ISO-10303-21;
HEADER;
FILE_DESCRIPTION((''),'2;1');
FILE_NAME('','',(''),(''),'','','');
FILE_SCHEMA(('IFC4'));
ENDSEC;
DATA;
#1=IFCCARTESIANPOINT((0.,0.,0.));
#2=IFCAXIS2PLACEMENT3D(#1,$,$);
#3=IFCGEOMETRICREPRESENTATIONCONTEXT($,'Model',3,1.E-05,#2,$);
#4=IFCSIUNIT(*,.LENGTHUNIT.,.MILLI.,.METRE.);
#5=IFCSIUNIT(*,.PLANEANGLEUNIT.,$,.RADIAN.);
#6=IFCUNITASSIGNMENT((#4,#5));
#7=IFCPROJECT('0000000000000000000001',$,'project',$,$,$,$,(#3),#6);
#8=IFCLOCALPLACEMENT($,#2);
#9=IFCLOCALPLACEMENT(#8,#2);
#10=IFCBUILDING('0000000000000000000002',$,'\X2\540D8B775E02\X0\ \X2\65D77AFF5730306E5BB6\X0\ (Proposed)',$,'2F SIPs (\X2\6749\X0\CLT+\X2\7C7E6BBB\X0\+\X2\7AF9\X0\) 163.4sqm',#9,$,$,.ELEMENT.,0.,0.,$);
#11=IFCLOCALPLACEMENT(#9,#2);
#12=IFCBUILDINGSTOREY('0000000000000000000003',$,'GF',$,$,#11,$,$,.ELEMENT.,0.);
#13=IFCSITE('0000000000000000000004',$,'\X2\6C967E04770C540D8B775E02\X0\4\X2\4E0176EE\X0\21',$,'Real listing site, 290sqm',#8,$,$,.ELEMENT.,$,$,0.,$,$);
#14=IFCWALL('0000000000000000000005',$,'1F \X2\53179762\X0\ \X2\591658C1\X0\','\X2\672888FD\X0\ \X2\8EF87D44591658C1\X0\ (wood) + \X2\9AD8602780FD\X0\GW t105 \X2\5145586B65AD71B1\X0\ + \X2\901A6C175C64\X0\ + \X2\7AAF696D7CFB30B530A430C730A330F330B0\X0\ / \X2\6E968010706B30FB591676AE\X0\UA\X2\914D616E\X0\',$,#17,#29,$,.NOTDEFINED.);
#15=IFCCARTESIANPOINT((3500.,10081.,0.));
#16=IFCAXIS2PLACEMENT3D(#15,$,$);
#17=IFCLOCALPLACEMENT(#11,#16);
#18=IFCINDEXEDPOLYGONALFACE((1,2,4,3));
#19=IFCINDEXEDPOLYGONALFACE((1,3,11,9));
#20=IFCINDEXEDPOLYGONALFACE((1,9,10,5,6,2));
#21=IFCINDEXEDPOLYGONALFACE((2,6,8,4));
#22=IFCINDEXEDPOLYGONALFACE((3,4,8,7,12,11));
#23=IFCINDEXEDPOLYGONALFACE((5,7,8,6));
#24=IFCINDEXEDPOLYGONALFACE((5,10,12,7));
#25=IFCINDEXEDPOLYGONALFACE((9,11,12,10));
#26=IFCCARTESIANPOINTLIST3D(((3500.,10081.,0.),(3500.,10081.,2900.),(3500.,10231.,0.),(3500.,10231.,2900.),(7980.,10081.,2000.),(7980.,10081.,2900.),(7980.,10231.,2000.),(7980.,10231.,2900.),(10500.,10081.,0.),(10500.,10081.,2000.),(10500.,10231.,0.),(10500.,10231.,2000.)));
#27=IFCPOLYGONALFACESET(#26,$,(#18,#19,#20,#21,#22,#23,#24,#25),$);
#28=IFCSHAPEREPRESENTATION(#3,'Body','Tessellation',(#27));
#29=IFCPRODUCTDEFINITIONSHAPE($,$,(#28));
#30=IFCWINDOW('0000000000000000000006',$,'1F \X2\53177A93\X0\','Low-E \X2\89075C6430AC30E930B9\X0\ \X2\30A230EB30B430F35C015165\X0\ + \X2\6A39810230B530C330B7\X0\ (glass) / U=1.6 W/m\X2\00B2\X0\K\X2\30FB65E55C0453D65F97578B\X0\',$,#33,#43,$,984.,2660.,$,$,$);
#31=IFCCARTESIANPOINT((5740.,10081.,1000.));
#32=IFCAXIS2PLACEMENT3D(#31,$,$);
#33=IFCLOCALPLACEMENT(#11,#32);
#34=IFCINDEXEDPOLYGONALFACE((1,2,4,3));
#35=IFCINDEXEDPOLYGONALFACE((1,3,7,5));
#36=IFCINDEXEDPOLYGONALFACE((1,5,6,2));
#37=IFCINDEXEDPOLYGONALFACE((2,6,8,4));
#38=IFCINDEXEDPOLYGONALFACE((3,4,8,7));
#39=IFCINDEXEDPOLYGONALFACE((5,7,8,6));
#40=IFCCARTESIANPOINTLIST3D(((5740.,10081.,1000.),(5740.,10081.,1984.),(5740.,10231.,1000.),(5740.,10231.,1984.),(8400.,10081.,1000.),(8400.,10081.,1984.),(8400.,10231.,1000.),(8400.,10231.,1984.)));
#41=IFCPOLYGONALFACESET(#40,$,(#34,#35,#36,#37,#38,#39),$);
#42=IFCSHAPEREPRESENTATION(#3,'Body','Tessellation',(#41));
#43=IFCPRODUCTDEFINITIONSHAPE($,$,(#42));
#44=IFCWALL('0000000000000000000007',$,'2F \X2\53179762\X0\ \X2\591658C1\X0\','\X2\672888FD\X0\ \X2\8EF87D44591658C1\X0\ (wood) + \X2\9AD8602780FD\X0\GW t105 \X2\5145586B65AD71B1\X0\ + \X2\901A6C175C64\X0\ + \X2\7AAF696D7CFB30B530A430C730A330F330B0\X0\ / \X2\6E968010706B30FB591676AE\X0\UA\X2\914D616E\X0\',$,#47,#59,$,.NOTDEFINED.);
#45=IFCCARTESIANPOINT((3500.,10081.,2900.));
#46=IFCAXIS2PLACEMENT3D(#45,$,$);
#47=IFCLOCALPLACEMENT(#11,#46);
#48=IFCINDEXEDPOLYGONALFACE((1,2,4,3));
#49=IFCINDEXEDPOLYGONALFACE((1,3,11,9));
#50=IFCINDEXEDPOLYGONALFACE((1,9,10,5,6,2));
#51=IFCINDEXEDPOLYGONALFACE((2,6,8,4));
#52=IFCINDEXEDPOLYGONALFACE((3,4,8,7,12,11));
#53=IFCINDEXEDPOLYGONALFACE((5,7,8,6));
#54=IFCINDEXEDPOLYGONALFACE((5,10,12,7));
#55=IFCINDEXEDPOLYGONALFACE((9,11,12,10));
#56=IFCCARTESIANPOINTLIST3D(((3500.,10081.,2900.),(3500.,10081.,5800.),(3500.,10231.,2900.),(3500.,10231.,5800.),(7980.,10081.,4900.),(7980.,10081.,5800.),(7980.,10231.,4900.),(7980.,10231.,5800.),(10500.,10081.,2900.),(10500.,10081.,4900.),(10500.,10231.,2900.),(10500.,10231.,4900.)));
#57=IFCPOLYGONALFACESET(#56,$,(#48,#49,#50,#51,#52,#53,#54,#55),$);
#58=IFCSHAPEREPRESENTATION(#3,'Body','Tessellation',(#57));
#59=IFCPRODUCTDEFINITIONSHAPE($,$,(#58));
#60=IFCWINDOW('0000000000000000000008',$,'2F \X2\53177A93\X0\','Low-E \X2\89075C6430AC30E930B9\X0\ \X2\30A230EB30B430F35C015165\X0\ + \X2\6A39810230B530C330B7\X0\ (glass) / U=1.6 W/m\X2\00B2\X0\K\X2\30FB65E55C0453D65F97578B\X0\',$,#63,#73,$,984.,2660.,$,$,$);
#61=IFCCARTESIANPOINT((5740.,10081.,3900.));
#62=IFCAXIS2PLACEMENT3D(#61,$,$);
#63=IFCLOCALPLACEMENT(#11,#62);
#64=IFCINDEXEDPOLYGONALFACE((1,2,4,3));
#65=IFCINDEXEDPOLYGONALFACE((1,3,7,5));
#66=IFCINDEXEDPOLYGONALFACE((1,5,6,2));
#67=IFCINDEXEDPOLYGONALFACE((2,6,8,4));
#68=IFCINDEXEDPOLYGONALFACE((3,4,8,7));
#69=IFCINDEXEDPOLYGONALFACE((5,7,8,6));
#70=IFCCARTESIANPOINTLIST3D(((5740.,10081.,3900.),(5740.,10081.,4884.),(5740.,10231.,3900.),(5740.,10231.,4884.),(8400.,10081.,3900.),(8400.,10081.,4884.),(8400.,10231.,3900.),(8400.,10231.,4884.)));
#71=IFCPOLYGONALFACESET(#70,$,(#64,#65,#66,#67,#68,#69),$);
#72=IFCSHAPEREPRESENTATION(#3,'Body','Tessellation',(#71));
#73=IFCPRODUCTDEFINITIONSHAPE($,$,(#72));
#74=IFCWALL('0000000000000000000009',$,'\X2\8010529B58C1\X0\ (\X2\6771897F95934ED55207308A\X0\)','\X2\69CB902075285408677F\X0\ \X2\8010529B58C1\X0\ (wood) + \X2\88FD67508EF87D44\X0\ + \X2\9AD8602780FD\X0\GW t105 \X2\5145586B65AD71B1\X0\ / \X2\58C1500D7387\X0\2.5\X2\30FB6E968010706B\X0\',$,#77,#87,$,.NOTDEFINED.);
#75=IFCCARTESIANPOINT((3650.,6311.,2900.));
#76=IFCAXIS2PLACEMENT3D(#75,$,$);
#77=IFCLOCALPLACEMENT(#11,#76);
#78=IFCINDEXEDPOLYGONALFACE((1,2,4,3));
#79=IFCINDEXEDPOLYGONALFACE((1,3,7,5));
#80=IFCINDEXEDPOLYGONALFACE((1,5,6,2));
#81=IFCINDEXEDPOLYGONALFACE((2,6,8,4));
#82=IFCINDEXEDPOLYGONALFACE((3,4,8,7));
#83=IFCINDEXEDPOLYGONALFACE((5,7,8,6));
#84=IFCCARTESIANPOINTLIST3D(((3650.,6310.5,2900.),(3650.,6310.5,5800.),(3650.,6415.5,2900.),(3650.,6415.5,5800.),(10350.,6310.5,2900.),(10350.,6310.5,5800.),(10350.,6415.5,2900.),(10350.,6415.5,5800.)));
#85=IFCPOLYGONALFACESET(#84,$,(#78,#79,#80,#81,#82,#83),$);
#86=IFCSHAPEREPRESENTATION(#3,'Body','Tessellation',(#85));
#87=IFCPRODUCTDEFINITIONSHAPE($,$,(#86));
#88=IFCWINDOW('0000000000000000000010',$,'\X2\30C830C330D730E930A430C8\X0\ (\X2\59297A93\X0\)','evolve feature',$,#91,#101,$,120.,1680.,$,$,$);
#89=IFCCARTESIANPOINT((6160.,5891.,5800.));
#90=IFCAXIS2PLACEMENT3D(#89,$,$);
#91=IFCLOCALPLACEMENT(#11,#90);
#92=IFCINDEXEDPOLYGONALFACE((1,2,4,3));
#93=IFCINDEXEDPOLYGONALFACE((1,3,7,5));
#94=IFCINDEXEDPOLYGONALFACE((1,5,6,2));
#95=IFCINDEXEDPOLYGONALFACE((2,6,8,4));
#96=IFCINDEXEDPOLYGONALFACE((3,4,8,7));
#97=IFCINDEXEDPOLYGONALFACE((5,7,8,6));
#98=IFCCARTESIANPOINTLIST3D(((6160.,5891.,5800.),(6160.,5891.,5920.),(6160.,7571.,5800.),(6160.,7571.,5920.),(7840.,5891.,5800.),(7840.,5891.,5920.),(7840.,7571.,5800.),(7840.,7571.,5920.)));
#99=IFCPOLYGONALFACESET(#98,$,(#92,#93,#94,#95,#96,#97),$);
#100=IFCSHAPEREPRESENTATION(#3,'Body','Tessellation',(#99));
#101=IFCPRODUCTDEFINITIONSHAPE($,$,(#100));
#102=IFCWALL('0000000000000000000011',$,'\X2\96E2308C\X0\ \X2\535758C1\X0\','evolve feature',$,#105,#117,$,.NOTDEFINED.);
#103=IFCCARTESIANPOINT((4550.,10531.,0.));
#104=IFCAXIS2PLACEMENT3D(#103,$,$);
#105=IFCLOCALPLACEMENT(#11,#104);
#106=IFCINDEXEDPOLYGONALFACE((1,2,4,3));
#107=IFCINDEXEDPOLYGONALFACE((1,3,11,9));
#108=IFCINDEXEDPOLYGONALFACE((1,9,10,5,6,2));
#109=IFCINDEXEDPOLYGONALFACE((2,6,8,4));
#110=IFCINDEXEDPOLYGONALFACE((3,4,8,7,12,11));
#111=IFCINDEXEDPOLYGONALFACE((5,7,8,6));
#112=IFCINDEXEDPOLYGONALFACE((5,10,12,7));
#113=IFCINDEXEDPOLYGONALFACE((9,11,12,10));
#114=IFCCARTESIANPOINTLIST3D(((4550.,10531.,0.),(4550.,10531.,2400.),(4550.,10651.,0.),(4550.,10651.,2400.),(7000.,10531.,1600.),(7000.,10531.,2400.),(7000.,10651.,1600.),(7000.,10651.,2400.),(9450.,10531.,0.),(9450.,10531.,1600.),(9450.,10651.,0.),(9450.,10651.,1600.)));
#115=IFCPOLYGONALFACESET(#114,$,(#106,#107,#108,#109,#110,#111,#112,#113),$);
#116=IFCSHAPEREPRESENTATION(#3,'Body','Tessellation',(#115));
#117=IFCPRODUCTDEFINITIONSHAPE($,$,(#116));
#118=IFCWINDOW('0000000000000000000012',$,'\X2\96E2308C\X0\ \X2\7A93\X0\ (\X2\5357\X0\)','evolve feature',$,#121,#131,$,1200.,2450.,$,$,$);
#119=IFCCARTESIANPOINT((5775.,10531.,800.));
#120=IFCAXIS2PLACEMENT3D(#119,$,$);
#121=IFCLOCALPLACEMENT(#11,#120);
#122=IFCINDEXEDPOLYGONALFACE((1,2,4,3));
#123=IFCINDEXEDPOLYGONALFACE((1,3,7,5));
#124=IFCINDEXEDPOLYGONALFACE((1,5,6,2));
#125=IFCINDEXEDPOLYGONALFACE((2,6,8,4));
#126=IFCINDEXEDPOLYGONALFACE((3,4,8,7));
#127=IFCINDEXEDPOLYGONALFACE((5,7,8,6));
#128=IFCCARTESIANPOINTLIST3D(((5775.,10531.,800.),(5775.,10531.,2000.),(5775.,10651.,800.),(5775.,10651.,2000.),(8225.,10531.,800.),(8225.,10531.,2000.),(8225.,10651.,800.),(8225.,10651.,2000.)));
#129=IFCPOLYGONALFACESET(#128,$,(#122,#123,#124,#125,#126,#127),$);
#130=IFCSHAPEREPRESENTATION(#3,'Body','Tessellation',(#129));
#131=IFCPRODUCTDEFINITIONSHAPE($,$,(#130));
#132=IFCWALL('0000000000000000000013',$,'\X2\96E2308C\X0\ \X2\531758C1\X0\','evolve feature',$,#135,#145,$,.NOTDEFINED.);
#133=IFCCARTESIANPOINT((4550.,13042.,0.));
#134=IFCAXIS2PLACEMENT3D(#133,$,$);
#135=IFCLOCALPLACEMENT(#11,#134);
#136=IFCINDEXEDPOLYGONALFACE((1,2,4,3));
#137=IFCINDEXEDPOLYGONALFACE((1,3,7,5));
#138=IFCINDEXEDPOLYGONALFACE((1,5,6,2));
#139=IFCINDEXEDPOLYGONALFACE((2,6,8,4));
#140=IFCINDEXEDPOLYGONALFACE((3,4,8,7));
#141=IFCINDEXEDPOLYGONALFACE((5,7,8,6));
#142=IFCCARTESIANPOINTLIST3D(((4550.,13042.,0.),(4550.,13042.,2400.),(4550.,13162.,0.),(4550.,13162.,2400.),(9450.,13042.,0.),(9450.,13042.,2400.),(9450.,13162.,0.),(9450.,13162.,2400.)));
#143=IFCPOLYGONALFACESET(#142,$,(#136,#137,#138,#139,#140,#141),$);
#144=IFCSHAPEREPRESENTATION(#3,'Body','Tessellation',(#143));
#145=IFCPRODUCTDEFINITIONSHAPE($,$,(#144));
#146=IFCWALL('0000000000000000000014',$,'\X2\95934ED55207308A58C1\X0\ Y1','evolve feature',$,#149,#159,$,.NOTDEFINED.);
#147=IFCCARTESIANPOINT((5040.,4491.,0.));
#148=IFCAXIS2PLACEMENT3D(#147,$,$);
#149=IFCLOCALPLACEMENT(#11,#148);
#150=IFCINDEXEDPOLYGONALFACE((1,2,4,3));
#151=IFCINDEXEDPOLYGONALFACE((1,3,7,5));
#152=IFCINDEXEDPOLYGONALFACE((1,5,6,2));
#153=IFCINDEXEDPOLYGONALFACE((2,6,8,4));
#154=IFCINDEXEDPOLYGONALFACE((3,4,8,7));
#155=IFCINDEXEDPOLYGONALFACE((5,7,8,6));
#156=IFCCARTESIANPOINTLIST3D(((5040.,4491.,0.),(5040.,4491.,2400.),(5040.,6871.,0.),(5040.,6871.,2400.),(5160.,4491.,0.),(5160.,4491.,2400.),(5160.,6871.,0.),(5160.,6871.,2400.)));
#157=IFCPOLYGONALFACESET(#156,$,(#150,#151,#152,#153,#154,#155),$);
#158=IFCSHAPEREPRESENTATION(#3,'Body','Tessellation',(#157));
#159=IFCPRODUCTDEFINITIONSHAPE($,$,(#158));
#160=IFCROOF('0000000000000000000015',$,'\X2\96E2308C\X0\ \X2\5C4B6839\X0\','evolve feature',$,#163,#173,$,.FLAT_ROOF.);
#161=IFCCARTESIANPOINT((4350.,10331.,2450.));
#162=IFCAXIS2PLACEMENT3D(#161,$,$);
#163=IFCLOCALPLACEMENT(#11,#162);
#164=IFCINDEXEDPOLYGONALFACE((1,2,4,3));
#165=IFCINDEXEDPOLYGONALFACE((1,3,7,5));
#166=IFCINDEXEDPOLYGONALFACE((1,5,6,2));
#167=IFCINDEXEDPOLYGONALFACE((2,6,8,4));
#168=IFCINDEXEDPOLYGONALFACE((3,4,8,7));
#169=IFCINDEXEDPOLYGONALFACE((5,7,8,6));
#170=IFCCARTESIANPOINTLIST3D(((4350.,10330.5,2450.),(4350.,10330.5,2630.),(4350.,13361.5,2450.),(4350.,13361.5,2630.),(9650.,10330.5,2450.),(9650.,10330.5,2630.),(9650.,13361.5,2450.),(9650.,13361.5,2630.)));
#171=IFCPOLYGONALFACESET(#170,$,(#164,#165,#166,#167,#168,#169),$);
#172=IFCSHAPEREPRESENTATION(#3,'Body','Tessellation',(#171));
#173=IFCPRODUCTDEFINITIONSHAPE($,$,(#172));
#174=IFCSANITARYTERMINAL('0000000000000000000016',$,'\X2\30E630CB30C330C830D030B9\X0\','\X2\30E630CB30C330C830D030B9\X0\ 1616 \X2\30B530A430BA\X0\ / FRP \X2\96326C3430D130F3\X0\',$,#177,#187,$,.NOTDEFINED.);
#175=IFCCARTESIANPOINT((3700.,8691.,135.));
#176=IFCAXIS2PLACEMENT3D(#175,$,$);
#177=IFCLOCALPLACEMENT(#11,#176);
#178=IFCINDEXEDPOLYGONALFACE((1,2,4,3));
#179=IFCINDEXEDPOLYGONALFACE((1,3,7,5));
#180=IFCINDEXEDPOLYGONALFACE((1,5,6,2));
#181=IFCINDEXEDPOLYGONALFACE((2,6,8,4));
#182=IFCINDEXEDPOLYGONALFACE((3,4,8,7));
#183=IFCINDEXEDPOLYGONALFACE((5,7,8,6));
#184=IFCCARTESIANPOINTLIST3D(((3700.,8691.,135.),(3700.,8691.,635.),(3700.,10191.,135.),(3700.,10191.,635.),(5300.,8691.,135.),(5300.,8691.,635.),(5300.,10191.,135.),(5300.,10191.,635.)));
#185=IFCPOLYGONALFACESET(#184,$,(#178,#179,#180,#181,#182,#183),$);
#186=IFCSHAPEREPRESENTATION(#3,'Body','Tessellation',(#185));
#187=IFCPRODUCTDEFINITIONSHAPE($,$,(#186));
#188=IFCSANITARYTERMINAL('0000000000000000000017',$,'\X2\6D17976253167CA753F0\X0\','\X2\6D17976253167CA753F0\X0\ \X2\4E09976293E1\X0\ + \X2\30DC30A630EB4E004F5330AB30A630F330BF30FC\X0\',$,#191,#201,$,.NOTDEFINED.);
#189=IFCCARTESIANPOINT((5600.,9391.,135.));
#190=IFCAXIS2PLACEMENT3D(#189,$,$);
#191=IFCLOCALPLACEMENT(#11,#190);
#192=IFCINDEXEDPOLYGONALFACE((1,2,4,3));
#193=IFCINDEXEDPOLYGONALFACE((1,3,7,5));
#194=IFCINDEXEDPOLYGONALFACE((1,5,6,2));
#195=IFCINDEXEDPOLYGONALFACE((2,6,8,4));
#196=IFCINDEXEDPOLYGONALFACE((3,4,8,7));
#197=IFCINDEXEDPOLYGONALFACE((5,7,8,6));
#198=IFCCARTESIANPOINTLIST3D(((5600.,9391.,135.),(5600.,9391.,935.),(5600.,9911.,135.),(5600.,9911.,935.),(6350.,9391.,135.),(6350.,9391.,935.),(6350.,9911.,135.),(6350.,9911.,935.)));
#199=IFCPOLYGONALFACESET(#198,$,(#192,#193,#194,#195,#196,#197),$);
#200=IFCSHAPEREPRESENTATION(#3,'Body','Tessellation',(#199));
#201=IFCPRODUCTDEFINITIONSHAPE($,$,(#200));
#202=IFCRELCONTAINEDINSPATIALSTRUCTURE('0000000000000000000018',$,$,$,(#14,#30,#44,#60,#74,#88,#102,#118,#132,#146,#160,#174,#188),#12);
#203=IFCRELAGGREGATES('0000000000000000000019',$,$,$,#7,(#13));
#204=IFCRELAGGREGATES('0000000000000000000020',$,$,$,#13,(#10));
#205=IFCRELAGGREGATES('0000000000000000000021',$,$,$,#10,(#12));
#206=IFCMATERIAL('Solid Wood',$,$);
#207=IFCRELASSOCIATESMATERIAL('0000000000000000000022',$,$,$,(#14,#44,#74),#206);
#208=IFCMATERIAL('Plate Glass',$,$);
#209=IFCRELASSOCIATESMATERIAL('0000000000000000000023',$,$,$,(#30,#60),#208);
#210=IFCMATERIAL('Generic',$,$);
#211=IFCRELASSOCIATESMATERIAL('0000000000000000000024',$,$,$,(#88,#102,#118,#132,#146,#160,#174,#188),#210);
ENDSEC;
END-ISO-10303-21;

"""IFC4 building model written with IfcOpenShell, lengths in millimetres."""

from ifc_helpers import new_model, si_unit, frame, frame_2d, origin, place, context, project, spatial, rectangle, extrude, material, element, fill, save


model = new_model("IFC4")

# Units and contexts
model_context = context("Model", 3, precision=1e-05, world=origin())
ifc_project = project(units=[si_unit("LENGTHUNIT", "METRE", prefix="MILLI"), si_unit("PLANEANGLEUNIT", "RADIAN")], contexts=[model_context])

# Site, building, storey
site_placement = place(None, origin())
site = spatial("IfcSite", under=ifc_project, at=site_placement, Name="沖縄県名護市4丁目21", ObjectType="Real listing site, 290sqm", CompositionType="ELEMENT", RefElevation=0.0)
building_placement = place(site_placement, origin())
building = spatial("IfcBuilding", under=site, at=building_placement, Name="名護市 旗竿地の家 (Proposed)", ObjectType="2F SIPs (杉CLT+籾殻+竹) 163.4sqm", CompositionType="ELEMENT", ElevationOfRefHeight=0.0, ElevationOfTerrain=0.0)
storey_placement = place(building_placement, origin())
storey = spatial("IfcBuildingStorey", under=building, at=storey_placement, Name="GF", CompositionType="ELEMENT", Elevation=0.0)

# Shared definitions
ifc_material_1 = material(Name="Generic")

# Wall, opening, window
ifc_material_2 = material(Name="Solid Wood")
wall_1_placement = place(storey_placement, frame((3500.0, 10081.0, 0.0)))
wall_1 = element("IfcWall", 1, at=wall_1_placement, inside=storey, material=ifc_material_2, Name="1F 北面 外壁", Description="木製 軸組外壁 (wood) + 高性能GW t105 充填断熱 + 通気層 + 窯業系サイディング / 準耐火・外皮UA配慮", PredefinedType="NOTDEFINED", context=model_context, shape_type="SweptSolid", body=[
    extrude(rectangle(XDim=7000.0, YDim=150.0, at=frame_2d((3500.0, 75.0))), frame((3500.0, 10081.0, 0.0)), (0.0, 0.0, 1.0), 2900.0),
])
opening_1_placement = place(storey_placement, frame((5740.0, 10081.0, 1000.0)))
opening_1 = element("IfcOpeningElement", 2, at=opening_1_placement, cuts=wall_1, PredefinedType="NOTDEFINED", context=model_context, shape_type="SweptSolid", body=[
    extrude(rectangle(XDim=2660.0, YDim=150.0, at=frame_2d((1330.0, 75.0))), frame((5740.0, 10081.0, 1000.0)), (0.0, 0.0, 1.0), 984.0),
])
ifc_material_3 = material(Name="Plate Glass")
window_1_placement = place(storey_placement, frame((5740.0, 10081.0, 1000.0)))
window_1 = element("IfcWindow", 3, at=window_1_placement, inside=storey, material=ifc_material_3, Name="1F 北窓", Description="Low-E 複層ガラス アルゴン封入 + 樹脂サッシ (glass) / U=1.6 W/m²K・日射取得型", OverallHeight=984.0, OverallWidth=2660.0, context=model_context, shape_type="SweptSolid", body=[
    extrude(rectangle(XDim=2660.0, YDim=150.0, at=frame_2d((1330.0, 75.0))), frame((5740.0, 10081.0, 1000.0)), (0.0, 0.0, 1.0), 984.0),
])
fill(opening_1, window_1)

# Wall, opening, window
wall_2_placement = place(storey_placement, frame((3500.0, 10081.0, 2900.0)))
wall_2 = element("IfcWall", 4, at=wall_2_placement, inside=storey, material=ifc_material_2, Name="2F 北面 外壁", Description="木製 軸組外壁 (wood) + 高性能GW t105 充填断熱 + 通気層 + 窯業系サイディング / 準耐火・外皮UA配慮", PredefinedType="NOTDEFINED", context=model_context, shape_type="SweptSolid", body=[
    extrude(rectangle(XDim=7000.0, YDim=150.0, at=frame_2d((3500.0, 75.0))), frame((3500.0, 10081.0, 2900.0)), (0.0, 0.0, 1.0), 2900.0),
])
opening_2_placement = place(storey_placement, frame((5740.0, 10081.0, 3900.0)))
opening_2 = element("IfcOpeningElement", 5, at=opening_2_placement, cuts=wall_2, PredefinedType="NOTDEFINED", context=model_context, shape_type="SweptSolid", body=[
    extrude(rectangle(XDim=2660.0, YDim=150.0, at=frame_2d((1330.0, 75.0))), frame((5740.0, 10081.0, 3900.0)), (0.0, 0.0, 1.0), 984.0),
])
window_2_placement = place(storey_placement, frame((5740.0, 10081.0, 3900.0)))
window_2 = element("IfcWindow", 6, at=window_2_placement, inside=storey, material=ifc_material_3, Name="2F 北窓", Description="Low-E 複層ガラス アルゴン封入 + 樹脂サッシ (glass) / U=1.6 W/m²K・日射取得型", OverallHeight=984.0, OverallWidth=2660.0, context=model_context, shape_type="SweptSolid", body=[
    extrude(rectangle(XDim=2660.0, YDim=150.0, at=frame_2d((1330.0, 75.0))), frame((5740.0, 10081.0, 3900.0)), (0.0, 0.0, 1.0), 984.0),
])
fill(opening_2, window_2)

# Wall
wall_3_placement = place(storey_placement, frame((3650.0, 6311.0, 2900.0)))
element("IfcWall", 7, at=wall_3_placement, inside=storey, material=ifc_material_2, Name="耐力壁 (東西間仕切り)", Description="構造用合板 耐力壁 (wood) + 製材軸組 + 高性能GW t105 充填断熱 / 壁倍率2.5・準耐火", PredefinedType="NOTDEFINED", context=model_context, shape_type="SweptSolid", body=[
    extrude(rectangle(XDim=6700.0, YDim=105.0, at=frame_2d((3350.0, 52.0))), frame((3650.0, 6311.0, 2900.0)), (0.0, 0.0, 1.0), 2900.0),
])

# Window
window_3_placement = place(storey_placement, frame((6160.0, 5891.0, 5800.0)))
element("IfcWindow", 8, at=window_3_placement, inside=storey, material=ifc_material_1, Name="トップライト (天窓)", Description="evolve feature", OverallHeight=120.0, OverallWidth=1680.0, context=model_context, shape_type="SweptSolid", body=[
    extrude(rectangle(XDim=1680.0, YDim=1680.0, at=frame_2d((840.0, 840.0))), frame((6160.0, 5891.0, 5800.0)), (0.0, 0.0, 1.0), 120.0),
])

# Wall, opening, window
wall_4_placement = place(storey_placement, frame((4550.0, 10531.0, 0.0)))
wall_4 = element("IfcWall", 9, at=wall_4_placement, inside=storey, material=ifc_material_1, Name="離れ 南壁", Description="evolve feature", PredefinedType="NOTDEFINED", context=model_context, shape_type="SweptSolid", body=[
    extrude(rectangle(XDim=4900.0, YDim=120.0, at=frame_2d((2450.0, 60.0))), frame((4550.0, 10531.0, 0.0)), (0.0, 0.0, 1.0), 2400.0),
])
opening_3_placement = place(storey_placement, frame((5775.0, 10531.0, 800.0)))
opening_3 = element("IfcOpeningElement", 10, at=opening_3_placement, cuts=wall_4, PredefinedType="NOTDEFINED", context=model_context, shape_type="SweptSolid", body=[
    extrude(rectangle(XDim=2450.0, YDim=120.0, at=frame_2d((1225.0, 60.0))), frame((5775.0, 10531.0, 800.0)), (0.0, 0.0, 1.0), 1200.0),
])
window_4_placement = place(storey_placement, frame((5775.0, 10531.0, 800.0)))
window_4 = element("IfcWindow", 11, at=window_4_placement, inside=storey, material=ifc_material_1, Name="離れ 窓 (南)", Description="evolve feature", OverallHeight=1200.0, OverallWidth=2450.0, context=model_context, shape_type="SweptSolid", body=[
    extrude(rectangle(XDim=2450.0, YDim=120.0, at=frame_2d((1225.0, 60.0))), frame((5775.0, 10531.0, 800.0)), (0.0, 0.0, 1.0), 1200.0),
])
fill(opening_3, window_4)

# Walls
wall_5_placement = place(storey_placement, frame((4550.0, 13042.0, 0.0)))
element("IfcWall", 12, at=wall_5_placement, inside=storey, material=ifc_material_1, Name="離れ 北壁", Description="evolve feature", PredefinedType="NOTDEFINED", context=model_context, shape_type="SweptSolid", body=[
    extrude(rectangle(XDim=4900.0, YDim=120.0, at=frame_2d((2450.0, 60.0))), frame((4550.0, 13042.0, 0.0)), (0.0, 0.0, 1.0), 2400.0),
])
wall_6_placement = place(storey_placement, frame((5040.0, 4491.0, 0.0)))
element("IfcWall", 13, at=wall_6_placement, inside=storey, material=ifc_material_1, Name="間仕切り壁 Y1", Description="evolve feature", PredefinedType="NOTDEFINED", context=model_context, shape_type="SweptSolid", body=[
    extrude(rectangle(XDim=120.0, YDim=2380.0, at=frame_2d((60.0, 1190.0))), frame((5040.0, 4491.0, 0.0)), (0.0, 0.0, 1.0), 2400.0),
])

# Roof
roof_placement = place(storey_placement, frame((4350.0, 10331.0, 2450.0)))
element("IfcRoof", 14, at=roof_placement, inside=storey, material=ifc_material_1, Name="離れ 屋根", Description="evolve feature", PredefinedType="FLAT_ROOF", context=model_context, shape_type="SweptSolid", body=[
    extrude(rectangle(XDim=5300.0, YDim=3031.0, at=frame_2d((2650.0, 1515.0))), frame((4350.0, 10331.0, 2450.0)), (0.0, 0.0, 1.0), 180.0),
])

# Sanitary terminals
sanitary_terminal_1_placement = place(storey_placement, frame((3700.0, 8691.0, 135.0)))
element("IfcSanitaryTerminal", 15, at=sanitary_terminal_1_placement, inside=storey, material=ifc_material_1, Name="ユニットバス", Description="ユニットバス 1616 サイズ / FRP 防水パン", PredefinedType="NOTDEFINED", context=model_context, shape_type="SweptSolid", body=[
    extrude(rectangle(XDim=1600.0, YDim=1500.0, at=frame_2d((800.0, 750.0))), frame((3700.0, 8691.0, 135.0)), (0.0, 0.0, 1.0), 500.0),
])
sanitary_terminal_2_placement = place(storey_placement, frame((5600.0, 9391.0, 135.0)))
element("IfcSanitaryTerminal", 16, at=sanitary_terminal_2_placement, inside=storey, material=ifc_material_1, Name="洗面化粧台", Description="洗面化粧台 三面鏡 + ボウル一体カウンター", PredefinedType="NOTDEFINED", context=model_context, shape_type="SweptSolid", body=[
    extrude(rectangle(XDim=750.0, YDim=520.0, at=frame_2d((375.0, 260.0))), frame((5600.0, 9391.0, 135.0)), (0.0, 0.0, 1.0), 800.0),
])

save(model, "model.ifc")
